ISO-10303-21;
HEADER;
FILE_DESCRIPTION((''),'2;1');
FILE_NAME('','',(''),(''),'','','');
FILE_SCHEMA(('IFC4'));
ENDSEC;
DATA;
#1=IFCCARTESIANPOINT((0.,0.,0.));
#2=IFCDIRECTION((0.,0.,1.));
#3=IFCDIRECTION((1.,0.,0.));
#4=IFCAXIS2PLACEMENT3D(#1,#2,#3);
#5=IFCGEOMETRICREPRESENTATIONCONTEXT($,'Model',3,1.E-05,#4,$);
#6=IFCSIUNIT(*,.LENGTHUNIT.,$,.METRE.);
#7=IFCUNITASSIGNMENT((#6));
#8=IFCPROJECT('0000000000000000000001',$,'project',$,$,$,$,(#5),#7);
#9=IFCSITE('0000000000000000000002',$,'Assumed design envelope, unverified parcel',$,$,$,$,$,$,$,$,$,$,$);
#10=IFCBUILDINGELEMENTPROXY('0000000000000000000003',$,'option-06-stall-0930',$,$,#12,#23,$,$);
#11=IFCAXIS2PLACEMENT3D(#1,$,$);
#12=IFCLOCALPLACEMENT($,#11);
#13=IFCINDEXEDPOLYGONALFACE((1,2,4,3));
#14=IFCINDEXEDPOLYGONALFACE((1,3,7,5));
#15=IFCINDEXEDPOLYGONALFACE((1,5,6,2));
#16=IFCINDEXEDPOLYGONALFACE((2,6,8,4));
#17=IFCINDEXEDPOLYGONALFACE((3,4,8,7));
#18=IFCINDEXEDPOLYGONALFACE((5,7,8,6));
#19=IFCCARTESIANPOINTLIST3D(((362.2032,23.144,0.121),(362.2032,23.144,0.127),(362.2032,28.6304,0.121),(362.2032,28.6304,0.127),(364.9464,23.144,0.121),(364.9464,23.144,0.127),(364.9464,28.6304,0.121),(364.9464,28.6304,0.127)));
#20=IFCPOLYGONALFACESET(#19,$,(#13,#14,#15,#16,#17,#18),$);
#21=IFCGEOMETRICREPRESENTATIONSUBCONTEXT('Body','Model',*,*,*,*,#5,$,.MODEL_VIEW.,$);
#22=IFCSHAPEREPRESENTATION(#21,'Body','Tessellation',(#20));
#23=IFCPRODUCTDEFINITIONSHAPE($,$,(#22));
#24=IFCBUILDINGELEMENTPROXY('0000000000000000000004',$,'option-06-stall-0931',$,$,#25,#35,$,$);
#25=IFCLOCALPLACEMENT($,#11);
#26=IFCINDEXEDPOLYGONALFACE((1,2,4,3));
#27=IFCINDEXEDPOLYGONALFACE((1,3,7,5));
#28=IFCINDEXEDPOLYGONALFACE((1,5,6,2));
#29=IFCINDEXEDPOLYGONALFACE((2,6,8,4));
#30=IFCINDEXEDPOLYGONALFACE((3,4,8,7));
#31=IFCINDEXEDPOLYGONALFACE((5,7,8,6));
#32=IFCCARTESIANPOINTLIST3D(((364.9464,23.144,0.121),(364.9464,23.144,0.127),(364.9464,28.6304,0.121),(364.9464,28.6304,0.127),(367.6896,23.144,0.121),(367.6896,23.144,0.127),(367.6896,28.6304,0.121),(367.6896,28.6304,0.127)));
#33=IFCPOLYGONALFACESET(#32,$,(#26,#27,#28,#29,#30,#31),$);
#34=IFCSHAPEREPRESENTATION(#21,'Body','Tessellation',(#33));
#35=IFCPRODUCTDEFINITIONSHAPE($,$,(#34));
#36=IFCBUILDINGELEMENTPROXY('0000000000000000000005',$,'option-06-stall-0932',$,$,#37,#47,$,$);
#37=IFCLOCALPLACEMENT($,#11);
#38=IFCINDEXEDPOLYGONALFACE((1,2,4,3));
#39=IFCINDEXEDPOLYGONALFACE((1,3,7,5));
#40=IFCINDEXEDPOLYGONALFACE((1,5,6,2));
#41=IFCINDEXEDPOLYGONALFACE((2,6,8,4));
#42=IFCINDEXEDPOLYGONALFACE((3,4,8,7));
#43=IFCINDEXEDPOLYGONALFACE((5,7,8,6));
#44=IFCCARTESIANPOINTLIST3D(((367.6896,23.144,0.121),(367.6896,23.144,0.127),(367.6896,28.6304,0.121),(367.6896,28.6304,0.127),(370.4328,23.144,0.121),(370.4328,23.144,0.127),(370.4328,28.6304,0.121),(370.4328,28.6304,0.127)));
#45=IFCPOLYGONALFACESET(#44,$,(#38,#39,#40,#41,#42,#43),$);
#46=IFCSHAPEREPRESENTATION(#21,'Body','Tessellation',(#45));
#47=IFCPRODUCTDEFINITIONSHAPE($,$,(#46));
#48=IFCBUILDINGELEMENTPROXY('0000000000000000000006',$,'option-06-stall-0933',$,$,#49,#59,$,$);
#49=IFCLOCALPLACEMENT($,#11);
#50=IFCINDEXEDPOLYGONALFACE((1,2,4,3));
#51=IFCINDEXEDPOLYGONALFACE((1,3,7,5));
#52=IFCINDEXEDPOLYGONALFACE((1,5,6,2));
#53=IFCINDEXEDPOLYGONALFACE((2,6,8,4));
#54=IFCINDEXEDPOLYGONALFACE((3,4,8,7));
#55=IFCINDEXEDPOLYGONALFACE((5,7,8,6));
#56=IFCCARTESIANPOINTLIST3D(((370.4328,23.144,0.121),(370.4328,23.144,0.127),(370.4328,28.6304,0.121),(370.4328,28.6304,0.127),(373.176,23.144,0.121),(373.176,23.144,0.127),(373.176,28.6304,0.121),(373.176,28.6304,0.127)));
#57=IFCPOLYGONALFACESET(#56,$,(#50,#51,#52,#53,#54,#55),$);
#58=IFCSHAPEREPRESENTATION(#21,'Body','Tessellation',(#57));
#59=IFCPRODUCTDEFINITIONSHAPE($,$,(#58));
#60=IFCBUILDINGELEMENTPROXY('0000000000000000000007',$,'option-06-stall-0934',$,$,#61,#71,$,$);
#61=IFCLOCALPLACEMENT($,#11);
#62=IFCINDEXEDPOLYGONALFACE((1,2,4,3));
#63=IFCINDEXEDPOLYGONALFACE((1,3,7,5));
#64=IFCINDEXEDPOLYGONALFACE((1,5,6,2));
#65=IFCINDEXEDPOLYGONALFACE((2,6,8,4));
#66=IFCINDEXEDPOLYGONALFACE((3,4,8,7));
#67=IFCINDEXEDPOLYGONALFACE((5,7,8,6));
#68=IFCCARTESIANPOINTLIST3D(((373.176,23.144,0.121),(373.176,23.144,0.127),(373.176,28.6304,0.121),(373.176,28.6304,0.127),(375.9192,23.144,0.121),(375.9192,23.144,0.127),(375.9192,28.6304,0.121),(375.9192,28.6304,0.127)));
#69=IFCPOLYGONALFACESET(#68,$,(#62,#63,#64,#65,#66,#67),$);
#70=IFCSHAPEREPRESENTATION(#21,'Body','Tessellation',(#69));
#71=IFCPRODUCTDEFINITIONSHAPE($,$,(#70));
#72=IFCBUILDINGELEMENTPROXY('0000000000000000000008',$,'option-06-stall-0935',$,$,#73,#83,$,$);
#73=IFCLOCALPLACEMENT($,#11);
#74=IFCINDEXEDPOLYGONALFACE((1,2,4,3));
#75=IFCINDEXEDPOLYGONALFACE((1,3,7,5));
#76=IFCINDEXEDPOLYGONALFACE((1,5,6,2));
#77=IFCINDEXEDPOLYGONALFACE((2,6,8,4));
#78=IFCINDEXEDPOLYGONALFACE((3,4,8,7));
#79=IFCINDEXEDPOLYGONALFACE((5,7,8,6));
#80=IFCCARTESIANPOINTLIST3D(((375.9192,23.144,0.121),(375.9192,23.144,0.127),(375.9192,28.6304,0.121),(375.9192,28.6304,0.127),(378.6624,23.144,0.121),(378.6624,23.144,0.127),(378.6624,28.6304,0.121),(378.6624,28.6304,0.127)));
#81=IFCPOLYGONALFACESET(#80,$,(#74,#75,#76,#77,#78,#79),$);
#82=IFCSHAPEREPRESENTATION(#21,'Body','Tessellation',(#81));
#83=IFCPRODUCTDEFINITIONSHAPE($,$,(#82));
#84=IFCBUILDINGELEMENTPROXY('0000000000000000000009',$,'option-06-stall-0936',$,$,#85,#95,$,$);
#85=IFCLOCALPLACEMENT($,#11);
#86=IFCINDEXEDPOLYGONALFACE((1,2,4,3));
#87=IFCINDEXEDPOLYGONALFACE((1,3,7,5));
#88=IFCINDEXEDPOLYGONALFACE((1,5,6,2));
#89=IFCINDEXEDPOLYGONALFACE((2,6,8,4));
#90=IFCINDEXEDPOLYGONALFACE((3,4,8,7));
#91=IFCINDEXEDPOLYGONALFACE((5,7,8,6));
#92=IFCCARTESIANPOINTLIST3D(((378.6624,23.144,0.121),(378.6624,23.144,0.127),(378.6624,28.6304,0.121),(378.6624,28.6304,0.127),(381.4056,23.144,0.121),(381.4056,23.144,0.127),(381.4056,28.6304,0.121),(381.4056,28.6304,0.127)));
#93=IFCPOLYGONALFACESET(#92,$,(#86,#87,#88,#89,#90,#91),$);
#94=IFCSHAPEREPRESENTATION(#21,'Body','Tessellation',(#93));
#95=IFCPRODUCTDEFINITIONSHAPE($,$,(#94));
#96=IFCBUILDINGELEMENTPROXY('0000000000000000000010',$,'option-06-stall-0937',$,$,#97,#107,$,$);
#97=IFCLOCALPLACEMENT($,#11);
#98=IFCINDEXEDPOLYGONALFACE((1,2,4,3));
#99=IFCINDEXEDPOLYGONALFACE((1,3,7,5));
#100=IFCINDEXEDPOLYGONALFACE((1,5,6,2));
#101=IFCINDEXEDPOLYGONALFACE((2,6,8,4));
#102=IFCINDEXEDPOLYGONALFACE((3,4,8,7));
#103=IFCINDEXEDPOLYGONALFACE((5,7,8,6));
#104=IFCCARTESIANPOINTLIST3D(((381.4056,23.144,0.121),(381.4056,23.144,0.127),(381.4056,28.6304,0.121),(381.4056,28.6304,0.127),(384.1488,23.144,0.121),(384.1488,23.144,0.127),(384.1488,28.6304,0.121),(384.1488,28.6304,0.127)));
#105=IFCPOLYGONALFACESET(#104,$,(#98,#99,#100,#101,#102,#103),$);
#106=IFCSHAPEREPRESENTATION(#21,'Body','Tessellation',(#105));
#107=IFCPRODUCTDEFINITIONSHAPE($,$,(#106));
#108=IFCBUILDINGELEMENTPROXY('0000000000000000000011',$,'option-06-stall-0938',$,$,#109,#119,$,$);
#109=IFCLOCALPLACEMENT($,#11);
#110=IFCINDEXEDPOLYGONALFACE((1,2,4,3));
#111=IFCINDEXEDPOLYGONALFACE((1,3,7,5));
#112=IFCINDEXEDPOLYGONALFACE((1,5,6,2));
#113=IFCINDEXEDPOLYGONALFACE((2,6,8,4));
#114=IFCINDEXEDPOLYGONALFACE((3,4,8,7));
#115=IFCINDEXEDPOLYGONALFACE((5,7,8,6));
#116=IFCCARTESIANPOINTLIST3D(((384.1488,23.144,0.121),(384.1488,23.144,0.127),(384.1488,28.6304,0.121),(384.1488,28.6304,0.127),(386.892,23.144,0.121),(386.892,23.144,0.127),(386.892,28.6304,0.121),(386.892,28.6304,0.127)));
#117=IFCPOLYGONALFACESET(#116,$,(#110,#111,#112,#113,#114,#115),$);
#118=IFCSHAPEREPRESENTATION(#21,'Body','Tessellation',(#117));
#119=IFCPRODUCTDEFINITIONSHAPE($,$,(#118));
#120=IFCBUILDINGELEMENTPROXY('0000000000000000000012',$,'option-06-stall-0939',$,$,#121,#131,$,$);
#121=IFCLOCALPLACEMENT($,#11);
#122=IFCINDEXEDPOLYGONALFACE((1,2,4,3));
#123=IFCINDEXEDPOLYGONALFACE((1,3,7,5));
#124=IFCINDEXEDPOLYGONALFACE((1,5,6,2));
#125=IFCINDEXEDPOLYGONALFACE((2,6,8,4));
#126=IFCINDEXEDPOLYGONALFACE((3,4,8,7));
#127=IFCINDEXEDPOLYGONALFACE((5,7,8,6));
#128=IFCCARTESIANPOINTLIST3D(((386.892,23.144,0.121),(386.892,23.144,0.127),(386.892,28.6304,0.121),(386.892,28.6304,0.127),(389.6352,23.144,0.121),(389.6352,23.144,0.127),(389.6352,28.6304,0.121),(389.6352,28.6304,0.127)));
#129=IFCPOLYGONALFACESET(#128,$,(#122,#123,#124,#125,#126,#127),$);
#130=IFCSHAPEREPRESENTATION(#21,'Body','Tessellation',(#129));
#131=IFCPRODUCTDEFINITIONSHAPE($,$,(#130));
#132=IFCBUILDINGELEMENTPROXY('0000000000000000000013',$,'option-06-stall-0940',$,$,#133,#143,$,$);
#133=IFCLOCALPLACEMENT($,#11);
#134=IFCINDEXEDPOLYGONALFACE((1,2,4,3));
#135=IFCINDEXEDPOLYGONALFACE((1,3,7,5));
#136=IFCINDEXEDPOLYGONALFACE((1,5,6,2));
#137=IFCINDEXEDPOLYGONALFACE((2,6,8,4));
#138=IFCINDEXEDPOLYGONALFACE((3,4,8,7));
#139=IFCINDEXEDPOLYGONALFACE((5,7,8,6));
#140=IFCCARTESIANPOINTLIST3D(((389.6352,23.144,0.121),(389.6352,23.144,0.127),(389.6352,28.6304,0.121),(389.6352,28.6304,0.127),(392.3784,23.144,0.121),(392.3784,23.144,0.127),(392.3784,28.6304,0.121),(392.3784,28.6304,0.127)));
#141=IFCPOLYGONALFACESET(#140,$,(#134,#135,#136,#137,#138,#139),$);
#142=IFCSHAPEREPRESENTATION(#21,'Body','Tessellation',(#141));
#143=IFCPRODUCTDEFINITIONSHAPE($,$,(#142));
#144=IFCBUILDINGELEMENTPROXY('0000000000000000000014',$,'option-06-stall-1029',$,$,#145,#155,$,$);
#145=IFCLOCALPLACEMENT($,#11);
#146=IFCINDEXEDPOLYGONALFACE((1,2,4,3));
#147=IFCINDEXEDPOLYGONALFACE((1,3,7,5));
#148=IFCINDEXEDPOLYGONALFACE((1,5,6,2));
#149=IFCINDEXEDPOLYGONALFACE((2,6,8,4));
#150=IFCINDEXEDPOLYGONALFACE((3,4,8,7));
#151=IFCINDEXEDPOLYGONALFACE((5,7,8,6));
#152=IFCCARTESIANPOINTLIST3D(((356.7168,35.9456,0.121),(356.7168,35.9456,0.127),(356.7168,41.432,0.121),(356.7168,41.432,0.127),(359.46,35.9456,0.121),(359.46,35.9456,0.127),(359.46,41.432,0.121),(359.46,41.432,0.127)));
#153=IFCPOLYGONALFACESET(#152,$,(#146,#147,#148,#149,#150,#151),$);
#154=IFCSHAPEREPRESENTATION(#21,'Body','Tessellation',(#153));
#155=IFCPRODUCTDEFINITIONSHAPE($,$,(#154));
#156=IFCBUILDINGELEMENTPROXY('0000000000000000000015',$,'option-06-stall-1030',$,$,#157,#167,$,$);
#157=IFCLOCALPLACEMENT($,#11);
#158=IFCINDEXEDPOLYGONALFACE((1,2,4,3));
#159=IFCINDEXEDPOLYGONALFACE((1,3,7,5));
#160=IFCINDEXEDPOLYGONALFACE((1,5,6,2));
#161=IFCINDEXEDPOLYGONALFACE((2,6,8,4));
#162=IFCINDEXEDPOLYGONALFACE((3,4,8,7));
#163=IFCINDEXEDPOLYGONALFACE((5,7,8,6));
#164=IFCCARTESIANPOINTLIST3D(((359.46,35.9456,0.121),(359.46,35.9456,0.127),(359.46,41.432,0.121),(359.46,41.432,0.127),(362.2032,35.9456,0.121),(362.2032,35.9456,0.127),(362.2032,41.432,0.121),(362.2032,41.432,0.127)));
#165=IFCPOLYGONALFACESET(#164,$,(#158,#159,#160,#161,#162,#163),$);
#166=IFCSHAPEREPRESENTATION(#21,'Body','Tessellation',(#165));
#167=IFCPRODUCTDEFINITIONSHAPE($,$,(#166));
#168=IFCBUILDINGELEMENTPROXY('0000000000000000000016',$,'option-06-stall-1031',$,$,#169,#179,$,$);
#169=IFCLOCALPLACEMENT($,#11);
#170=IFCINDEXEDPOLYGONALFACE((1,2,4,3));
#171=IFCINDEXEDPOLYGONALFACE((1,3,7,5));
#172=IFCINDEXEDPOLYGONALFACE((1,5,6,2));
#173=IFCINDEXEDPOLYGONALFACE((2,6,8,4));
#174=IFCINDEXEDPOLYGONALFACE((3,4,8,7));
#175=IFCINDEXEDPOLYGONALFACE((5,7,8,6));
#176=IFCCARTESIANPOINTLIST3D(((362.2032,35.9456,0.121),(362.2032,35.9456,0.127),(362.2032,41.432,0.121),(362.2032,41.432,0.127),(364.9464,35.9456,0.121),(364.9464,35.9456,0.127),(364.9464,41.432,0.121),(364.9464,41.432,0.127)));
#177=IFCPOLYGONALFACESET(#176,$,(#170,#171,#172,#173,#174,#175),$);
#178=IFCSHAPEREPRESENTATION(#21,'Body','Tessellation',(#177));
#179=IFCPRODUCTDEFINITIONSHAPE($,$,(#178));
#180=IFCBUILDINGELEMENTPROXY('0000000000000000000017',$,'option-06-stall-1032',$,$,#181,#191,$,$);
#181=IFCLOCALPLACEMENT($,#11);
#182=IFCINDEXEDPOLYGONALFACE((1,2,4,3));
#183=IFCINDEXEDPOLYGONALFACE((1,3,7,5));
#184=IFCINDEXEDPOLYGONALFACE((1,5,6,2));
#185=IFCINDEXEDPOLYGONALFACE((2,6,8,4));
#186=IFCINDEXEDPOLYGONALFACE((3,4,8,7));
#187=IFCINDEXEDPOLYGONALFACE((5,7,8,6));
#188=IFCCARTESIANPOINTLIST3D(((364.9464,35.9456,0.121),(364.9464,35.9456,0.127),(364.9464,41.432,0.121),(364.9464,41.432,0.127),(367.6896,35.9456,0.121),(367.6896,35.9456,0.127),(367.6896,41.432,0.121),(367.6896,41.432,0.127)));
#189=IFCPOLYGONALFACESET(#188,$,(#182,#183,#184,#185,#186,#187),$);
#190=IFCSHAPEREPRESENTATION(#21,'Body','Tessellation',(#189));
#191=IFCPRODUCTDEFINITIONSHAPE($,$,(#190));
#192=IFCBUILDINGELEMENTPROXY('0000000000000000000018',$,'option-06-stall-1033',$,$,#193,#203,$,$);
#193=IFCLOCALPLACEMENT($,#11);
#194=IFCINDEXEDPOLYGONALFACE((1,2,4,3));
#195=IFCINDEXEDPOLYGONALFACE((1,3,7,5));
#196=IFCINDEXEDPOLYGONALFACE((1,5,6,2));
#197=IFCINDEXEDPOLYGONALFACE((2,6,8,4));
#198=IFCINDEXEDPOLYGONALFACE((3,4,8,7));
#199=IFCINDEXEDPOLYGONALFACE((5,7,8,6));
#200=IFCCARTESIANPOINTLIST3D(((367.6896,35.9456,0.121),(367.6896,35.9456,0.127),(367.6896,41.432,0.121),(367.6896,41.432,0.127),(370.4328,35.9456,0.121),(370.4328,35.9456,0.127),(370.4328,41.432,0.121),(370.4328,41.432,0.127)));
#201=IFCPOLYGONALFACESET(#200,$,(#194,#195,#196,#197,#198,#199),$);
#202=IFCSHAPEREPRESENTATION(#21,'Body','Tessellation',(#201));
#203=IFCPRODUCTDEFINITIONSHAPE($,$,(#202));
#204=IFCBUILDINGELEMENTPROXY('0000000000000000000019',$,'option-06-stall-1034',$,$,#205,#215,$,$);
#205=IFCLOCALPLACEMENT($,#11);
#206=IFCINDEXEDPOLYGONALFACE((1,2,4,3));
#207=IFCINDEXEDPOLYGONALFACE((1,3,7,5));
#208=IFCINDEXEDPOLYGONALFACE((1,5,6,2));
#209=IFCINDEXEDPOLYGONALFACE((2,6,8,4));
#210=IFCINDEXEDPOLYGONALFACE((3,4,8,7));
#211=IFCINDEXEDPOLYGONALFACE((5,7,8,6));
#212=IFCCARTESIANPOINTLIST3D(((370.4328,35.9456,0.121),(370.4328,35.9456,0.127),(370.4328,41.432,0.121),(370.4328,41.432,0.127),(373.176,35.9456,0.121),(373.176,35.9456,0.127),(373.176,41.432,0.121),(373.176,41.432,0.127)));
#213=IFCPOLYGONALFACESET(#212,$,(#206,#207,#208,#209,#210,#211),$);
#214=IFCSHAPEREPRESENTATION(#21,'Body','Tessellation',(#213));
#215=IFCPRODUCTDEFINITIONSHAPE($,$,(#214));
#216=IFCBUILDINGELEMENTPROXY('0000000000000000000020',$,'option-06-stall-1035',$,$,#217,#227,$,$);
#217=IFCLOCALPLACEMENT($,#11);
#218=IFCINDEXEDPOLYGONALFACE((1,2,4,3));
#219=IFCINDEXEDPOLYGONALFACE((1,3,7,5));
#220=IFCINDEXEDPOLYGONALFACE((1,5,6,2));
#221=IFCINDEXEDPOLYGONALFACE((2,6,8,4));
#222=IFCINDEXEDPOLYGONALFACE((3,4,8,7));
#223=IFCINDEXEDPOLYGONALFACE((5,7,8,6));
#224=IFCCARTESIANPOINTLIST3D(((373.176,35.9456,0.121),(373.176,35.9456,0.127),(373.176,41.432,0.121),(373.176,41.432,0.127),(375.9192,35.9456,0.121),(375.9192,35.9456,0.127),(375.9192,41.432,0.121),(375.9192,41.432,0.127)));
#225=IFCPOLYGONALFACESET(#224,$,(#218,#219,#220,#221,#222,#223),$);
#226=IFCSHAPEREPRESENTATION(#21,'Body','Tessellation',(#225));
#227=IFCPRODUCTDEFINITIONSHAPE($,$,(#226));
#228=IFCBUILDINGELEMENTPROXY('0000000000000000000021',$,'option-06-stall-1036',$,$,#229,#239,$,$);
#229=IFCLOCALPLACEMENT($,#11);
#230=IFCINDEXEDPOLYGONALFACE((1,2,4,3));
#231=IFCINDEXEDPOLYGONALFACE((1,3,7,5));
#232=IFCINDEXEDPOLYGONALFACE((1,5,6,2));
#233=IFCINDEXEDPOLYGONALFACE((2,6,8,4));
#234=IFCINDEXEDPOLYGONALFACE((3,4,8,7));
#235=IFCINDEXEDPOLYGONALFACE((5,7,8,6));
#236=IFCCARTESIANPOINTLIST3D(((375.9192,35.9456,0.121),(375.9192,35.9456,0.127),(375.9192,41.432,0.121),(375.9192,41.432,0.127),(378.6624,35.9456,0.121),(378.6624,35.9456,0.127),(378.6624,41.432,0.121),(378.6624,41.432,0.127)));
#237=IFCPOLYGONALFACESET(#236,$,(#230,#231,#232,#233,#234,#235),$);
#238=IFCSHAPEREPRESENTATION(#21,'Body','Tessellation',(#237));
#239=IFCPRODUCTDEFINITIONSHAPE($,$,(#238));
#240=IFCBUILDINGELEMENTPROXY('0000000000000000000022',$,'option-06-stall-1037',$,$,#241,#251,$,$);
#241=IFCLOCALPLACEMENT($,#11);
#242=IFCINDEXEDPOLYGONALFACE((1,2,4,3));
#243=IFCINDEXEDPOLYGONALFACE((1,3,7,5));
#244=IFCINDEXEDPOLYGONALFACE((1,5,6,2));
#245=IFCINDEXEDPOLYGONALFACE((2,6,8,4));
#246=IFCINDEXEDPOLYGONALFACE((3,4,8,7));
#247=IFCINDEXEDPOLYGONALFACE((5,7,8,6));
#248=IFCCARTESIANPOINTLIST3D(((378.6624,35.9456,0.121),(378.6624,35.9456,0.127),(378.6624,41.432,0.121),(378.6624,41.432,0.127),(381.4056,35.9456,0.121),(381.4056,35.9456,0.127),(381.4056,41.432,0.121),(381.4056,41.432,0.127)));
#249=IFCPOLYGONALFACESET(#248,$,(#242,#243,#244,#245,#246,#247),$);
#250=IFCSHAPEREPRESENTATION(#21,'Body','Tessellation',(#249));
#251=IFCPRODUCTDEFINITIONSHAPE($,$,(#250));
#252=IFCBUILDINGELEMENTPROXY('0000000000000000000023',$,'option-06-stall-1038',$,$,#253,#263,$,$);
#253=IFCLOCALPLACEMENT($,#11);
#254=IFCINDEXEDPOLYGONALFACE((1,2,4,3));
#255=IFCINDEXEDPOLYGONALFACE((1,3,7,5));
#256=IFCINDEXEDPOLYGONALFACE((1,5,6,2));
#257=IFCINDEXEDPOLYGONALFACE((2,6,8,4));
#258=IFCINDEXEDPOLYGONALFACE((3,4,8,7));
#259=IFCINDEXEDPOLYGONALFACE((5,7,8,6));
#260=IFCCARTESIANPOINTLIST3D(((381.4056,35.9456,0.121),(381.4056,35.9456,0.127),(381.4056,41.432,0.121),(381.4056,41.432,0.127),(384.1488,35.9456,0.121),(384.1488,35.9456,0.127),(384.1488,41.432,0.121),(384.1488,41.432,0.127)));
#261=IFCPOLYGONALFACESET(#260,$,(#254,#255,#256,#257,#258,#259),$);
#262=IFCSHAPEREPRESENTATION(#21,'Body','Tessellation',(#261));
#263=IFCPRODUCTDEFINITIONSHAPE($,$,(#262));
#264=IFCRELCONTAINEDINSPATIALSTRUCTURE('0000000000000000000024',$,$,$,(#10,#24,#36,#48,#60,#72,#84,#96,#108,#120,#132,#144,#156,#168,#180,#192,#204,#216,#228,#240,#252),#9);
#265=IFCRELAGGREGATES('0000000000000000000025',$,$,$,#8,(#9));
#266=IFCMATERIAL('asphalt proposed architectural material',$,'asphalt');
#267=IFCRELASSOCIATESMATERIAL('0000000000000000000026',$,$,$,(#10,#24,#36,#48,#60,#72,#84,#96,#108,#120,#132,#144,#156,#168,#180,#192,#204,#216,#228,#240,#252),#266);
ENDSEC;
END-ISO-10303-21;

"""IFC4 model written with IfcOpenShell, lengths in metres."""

from ifc_helpers import new_model, si_unit, frame, origin_with_axes, place, context, subcontext, project, spatial, rectangle, extrude, material, element, save


model = new_model("IFC4")

# Units and contexts
model_context = context("Model", 3, precision=1e-05, world=origin_with_axes())
body_context = subcontext(model_context, "Body", "Model", "MODEL_VIEW")
ifc_project = project(units=[si_unit("LENGTHUNIT", "METRE")], contexts=[model_context])

# Site
site = spatial("IfcSite", under=ifc_project, Name="Assumed design envelope, unverified parcel")

# Building element proxies
ifc_material = material(Name="asphalt proposed architectural material", Category="asphalt")
for number, where, z_axis, x_axis, name in (
    (1, (363.5748, 25.8872, 0.121), (0.0, 0.0, 1.0), (1.0, 0.0, 0.0), "option-06-stall-0930"),
    (2, (366.318, 25.8872, 0.121), (0.0, 0.0, 1.0), (1.0, 0.0, 0.0), "option-06-stall-0931"),
    (3, (369.0612, 25.8872, 0.121), (0.0, 0.0, 1.0), (1.0, 0.0, 0.0), "option-06-stall-0932"),
    (4, (371.8044, 25.8872, 0.121), (0.0, 0.0, 1.0), (1.0, 0.0, 0.0), "option-06-stall-0933"),
    (5, (374.5476, 25.8872, 0.121), (0.0, 0.0, 1.0), (1.0, 0.0, 0.0), "option-06-stall-0934"),
    (6, (377.2908, 25.8872, 0.121), (0.0, 0.0, 1.0), (1.0, 0.0, 0.0), "option-06-stall-0935"),
    (7, (380.034, 25.8872, 0.121), (0.0, 0.0, 1.0), (1.0, 0.0, 0.0), "option-06-stall-0936"),
    (8, (382.7772, 25.8872, 0.121), (0.0, 0.0, 1.0), (1.0, 0.0, 0.0), "option-06-stall-0937"),
    (9, (385.5204, 25.8872, 0.121), (0.0, 0.0, 1.0), (1.0, 0.0, 0.0), "option-06-stall-0938"),
    (10, (388.2636, 25.8872, 0.121), (0.0, 0.0, 1.0), (1.0, 0.0, 0.0), "option-06-stall-0939"),
    (11, (391.0068, 25.8872, 0.121), (0.0, 0.0, 1.0), (1.0, 0.0, 0.0), "option-06-stall-0940"),
):
    element("IfcBuildingElementProxy", number, at=place(None, frame(where, z_axis=z_axis, x_axis=x_axis)), inside=site, material=ifc_material, Name=name, context=body_context, shape_type="SweptSolid", body=[
        extrude(rectangle(XDim=2.7432, YDim=5.4864), origin_with_axes(), (0.0, 0.0, 1.0), 0.006),
    ])
for number, where, z_axis, x_axis, name in (
    (12, (358.0884, 38.6888, 0.121), (0.0, 0.0, 1.0), (1.0, 0.0, 0.0), "option-06-stall-1029"),
    (13, (360.8316, 38.6888, 0.121), (0.0, 0.0, 1.0), (1.0, 0.0, 0.0), "option-06-stall-1030"),
    (14, (363.5748, 38.6888, 0.121), (0.0, 0.0, 1.0), (1.0, 0.0, 0.0), "option-06-stall-1031"),
    (15, (366.318, 38.6888, 0.121), (0.0, 0.0, 1.0), (1.0, 0.0, 0.0), "option-06-stall-1032"),
    (16, (369.0612, 38.6888, 0.121), (0.0, 0.0, 1.0), (1.0, 0.0, 0.0), "option-06-stall-1033"),
    (17, (371.8044, 38.6888, 0.121), (0.0, 0.0, 1.0), (1.0, 0.0, 0.0), "option-06-stall-1034"),
    (18, (374.5476, 38.6888, 0.121), (0.0, 0.0, 1.0), (1.0, 0.0, 0.0), "option-06-stall-1035"),
    (19, (377.2908, 38.6888, 0.121), (0.0, 0.0, 1.0), (1.0, 0.0, 0.0), "option-06-stall-1036"),
    (20, (380.034, 38.6888, 0.121), (0.0, 0.0, 1.0), (1.0, 0.0, 0.0), "option-06-stall-1037"),
    (21, (382.7772, 38.6888, 0.121), (0.0, 0.0, 1.0), (1.0, 0.0, 0.0), "option-06-stall-1038"),
):
    element("IfcBuildingElementProxy", number, at=place(None, frame(where, z_axis=z_axis, x_axis=x_axis)), inside=site, material=ifc_material, Name=name, context=body_context, shape_type="SweptSolid", body=[
        extrude(rectangle(XDim=2.7432, YDim=5.4864), origin_with_axes(), (0.0, 0.0, 1.0), 0.006),
    ])

save(model, "model.ifc")
